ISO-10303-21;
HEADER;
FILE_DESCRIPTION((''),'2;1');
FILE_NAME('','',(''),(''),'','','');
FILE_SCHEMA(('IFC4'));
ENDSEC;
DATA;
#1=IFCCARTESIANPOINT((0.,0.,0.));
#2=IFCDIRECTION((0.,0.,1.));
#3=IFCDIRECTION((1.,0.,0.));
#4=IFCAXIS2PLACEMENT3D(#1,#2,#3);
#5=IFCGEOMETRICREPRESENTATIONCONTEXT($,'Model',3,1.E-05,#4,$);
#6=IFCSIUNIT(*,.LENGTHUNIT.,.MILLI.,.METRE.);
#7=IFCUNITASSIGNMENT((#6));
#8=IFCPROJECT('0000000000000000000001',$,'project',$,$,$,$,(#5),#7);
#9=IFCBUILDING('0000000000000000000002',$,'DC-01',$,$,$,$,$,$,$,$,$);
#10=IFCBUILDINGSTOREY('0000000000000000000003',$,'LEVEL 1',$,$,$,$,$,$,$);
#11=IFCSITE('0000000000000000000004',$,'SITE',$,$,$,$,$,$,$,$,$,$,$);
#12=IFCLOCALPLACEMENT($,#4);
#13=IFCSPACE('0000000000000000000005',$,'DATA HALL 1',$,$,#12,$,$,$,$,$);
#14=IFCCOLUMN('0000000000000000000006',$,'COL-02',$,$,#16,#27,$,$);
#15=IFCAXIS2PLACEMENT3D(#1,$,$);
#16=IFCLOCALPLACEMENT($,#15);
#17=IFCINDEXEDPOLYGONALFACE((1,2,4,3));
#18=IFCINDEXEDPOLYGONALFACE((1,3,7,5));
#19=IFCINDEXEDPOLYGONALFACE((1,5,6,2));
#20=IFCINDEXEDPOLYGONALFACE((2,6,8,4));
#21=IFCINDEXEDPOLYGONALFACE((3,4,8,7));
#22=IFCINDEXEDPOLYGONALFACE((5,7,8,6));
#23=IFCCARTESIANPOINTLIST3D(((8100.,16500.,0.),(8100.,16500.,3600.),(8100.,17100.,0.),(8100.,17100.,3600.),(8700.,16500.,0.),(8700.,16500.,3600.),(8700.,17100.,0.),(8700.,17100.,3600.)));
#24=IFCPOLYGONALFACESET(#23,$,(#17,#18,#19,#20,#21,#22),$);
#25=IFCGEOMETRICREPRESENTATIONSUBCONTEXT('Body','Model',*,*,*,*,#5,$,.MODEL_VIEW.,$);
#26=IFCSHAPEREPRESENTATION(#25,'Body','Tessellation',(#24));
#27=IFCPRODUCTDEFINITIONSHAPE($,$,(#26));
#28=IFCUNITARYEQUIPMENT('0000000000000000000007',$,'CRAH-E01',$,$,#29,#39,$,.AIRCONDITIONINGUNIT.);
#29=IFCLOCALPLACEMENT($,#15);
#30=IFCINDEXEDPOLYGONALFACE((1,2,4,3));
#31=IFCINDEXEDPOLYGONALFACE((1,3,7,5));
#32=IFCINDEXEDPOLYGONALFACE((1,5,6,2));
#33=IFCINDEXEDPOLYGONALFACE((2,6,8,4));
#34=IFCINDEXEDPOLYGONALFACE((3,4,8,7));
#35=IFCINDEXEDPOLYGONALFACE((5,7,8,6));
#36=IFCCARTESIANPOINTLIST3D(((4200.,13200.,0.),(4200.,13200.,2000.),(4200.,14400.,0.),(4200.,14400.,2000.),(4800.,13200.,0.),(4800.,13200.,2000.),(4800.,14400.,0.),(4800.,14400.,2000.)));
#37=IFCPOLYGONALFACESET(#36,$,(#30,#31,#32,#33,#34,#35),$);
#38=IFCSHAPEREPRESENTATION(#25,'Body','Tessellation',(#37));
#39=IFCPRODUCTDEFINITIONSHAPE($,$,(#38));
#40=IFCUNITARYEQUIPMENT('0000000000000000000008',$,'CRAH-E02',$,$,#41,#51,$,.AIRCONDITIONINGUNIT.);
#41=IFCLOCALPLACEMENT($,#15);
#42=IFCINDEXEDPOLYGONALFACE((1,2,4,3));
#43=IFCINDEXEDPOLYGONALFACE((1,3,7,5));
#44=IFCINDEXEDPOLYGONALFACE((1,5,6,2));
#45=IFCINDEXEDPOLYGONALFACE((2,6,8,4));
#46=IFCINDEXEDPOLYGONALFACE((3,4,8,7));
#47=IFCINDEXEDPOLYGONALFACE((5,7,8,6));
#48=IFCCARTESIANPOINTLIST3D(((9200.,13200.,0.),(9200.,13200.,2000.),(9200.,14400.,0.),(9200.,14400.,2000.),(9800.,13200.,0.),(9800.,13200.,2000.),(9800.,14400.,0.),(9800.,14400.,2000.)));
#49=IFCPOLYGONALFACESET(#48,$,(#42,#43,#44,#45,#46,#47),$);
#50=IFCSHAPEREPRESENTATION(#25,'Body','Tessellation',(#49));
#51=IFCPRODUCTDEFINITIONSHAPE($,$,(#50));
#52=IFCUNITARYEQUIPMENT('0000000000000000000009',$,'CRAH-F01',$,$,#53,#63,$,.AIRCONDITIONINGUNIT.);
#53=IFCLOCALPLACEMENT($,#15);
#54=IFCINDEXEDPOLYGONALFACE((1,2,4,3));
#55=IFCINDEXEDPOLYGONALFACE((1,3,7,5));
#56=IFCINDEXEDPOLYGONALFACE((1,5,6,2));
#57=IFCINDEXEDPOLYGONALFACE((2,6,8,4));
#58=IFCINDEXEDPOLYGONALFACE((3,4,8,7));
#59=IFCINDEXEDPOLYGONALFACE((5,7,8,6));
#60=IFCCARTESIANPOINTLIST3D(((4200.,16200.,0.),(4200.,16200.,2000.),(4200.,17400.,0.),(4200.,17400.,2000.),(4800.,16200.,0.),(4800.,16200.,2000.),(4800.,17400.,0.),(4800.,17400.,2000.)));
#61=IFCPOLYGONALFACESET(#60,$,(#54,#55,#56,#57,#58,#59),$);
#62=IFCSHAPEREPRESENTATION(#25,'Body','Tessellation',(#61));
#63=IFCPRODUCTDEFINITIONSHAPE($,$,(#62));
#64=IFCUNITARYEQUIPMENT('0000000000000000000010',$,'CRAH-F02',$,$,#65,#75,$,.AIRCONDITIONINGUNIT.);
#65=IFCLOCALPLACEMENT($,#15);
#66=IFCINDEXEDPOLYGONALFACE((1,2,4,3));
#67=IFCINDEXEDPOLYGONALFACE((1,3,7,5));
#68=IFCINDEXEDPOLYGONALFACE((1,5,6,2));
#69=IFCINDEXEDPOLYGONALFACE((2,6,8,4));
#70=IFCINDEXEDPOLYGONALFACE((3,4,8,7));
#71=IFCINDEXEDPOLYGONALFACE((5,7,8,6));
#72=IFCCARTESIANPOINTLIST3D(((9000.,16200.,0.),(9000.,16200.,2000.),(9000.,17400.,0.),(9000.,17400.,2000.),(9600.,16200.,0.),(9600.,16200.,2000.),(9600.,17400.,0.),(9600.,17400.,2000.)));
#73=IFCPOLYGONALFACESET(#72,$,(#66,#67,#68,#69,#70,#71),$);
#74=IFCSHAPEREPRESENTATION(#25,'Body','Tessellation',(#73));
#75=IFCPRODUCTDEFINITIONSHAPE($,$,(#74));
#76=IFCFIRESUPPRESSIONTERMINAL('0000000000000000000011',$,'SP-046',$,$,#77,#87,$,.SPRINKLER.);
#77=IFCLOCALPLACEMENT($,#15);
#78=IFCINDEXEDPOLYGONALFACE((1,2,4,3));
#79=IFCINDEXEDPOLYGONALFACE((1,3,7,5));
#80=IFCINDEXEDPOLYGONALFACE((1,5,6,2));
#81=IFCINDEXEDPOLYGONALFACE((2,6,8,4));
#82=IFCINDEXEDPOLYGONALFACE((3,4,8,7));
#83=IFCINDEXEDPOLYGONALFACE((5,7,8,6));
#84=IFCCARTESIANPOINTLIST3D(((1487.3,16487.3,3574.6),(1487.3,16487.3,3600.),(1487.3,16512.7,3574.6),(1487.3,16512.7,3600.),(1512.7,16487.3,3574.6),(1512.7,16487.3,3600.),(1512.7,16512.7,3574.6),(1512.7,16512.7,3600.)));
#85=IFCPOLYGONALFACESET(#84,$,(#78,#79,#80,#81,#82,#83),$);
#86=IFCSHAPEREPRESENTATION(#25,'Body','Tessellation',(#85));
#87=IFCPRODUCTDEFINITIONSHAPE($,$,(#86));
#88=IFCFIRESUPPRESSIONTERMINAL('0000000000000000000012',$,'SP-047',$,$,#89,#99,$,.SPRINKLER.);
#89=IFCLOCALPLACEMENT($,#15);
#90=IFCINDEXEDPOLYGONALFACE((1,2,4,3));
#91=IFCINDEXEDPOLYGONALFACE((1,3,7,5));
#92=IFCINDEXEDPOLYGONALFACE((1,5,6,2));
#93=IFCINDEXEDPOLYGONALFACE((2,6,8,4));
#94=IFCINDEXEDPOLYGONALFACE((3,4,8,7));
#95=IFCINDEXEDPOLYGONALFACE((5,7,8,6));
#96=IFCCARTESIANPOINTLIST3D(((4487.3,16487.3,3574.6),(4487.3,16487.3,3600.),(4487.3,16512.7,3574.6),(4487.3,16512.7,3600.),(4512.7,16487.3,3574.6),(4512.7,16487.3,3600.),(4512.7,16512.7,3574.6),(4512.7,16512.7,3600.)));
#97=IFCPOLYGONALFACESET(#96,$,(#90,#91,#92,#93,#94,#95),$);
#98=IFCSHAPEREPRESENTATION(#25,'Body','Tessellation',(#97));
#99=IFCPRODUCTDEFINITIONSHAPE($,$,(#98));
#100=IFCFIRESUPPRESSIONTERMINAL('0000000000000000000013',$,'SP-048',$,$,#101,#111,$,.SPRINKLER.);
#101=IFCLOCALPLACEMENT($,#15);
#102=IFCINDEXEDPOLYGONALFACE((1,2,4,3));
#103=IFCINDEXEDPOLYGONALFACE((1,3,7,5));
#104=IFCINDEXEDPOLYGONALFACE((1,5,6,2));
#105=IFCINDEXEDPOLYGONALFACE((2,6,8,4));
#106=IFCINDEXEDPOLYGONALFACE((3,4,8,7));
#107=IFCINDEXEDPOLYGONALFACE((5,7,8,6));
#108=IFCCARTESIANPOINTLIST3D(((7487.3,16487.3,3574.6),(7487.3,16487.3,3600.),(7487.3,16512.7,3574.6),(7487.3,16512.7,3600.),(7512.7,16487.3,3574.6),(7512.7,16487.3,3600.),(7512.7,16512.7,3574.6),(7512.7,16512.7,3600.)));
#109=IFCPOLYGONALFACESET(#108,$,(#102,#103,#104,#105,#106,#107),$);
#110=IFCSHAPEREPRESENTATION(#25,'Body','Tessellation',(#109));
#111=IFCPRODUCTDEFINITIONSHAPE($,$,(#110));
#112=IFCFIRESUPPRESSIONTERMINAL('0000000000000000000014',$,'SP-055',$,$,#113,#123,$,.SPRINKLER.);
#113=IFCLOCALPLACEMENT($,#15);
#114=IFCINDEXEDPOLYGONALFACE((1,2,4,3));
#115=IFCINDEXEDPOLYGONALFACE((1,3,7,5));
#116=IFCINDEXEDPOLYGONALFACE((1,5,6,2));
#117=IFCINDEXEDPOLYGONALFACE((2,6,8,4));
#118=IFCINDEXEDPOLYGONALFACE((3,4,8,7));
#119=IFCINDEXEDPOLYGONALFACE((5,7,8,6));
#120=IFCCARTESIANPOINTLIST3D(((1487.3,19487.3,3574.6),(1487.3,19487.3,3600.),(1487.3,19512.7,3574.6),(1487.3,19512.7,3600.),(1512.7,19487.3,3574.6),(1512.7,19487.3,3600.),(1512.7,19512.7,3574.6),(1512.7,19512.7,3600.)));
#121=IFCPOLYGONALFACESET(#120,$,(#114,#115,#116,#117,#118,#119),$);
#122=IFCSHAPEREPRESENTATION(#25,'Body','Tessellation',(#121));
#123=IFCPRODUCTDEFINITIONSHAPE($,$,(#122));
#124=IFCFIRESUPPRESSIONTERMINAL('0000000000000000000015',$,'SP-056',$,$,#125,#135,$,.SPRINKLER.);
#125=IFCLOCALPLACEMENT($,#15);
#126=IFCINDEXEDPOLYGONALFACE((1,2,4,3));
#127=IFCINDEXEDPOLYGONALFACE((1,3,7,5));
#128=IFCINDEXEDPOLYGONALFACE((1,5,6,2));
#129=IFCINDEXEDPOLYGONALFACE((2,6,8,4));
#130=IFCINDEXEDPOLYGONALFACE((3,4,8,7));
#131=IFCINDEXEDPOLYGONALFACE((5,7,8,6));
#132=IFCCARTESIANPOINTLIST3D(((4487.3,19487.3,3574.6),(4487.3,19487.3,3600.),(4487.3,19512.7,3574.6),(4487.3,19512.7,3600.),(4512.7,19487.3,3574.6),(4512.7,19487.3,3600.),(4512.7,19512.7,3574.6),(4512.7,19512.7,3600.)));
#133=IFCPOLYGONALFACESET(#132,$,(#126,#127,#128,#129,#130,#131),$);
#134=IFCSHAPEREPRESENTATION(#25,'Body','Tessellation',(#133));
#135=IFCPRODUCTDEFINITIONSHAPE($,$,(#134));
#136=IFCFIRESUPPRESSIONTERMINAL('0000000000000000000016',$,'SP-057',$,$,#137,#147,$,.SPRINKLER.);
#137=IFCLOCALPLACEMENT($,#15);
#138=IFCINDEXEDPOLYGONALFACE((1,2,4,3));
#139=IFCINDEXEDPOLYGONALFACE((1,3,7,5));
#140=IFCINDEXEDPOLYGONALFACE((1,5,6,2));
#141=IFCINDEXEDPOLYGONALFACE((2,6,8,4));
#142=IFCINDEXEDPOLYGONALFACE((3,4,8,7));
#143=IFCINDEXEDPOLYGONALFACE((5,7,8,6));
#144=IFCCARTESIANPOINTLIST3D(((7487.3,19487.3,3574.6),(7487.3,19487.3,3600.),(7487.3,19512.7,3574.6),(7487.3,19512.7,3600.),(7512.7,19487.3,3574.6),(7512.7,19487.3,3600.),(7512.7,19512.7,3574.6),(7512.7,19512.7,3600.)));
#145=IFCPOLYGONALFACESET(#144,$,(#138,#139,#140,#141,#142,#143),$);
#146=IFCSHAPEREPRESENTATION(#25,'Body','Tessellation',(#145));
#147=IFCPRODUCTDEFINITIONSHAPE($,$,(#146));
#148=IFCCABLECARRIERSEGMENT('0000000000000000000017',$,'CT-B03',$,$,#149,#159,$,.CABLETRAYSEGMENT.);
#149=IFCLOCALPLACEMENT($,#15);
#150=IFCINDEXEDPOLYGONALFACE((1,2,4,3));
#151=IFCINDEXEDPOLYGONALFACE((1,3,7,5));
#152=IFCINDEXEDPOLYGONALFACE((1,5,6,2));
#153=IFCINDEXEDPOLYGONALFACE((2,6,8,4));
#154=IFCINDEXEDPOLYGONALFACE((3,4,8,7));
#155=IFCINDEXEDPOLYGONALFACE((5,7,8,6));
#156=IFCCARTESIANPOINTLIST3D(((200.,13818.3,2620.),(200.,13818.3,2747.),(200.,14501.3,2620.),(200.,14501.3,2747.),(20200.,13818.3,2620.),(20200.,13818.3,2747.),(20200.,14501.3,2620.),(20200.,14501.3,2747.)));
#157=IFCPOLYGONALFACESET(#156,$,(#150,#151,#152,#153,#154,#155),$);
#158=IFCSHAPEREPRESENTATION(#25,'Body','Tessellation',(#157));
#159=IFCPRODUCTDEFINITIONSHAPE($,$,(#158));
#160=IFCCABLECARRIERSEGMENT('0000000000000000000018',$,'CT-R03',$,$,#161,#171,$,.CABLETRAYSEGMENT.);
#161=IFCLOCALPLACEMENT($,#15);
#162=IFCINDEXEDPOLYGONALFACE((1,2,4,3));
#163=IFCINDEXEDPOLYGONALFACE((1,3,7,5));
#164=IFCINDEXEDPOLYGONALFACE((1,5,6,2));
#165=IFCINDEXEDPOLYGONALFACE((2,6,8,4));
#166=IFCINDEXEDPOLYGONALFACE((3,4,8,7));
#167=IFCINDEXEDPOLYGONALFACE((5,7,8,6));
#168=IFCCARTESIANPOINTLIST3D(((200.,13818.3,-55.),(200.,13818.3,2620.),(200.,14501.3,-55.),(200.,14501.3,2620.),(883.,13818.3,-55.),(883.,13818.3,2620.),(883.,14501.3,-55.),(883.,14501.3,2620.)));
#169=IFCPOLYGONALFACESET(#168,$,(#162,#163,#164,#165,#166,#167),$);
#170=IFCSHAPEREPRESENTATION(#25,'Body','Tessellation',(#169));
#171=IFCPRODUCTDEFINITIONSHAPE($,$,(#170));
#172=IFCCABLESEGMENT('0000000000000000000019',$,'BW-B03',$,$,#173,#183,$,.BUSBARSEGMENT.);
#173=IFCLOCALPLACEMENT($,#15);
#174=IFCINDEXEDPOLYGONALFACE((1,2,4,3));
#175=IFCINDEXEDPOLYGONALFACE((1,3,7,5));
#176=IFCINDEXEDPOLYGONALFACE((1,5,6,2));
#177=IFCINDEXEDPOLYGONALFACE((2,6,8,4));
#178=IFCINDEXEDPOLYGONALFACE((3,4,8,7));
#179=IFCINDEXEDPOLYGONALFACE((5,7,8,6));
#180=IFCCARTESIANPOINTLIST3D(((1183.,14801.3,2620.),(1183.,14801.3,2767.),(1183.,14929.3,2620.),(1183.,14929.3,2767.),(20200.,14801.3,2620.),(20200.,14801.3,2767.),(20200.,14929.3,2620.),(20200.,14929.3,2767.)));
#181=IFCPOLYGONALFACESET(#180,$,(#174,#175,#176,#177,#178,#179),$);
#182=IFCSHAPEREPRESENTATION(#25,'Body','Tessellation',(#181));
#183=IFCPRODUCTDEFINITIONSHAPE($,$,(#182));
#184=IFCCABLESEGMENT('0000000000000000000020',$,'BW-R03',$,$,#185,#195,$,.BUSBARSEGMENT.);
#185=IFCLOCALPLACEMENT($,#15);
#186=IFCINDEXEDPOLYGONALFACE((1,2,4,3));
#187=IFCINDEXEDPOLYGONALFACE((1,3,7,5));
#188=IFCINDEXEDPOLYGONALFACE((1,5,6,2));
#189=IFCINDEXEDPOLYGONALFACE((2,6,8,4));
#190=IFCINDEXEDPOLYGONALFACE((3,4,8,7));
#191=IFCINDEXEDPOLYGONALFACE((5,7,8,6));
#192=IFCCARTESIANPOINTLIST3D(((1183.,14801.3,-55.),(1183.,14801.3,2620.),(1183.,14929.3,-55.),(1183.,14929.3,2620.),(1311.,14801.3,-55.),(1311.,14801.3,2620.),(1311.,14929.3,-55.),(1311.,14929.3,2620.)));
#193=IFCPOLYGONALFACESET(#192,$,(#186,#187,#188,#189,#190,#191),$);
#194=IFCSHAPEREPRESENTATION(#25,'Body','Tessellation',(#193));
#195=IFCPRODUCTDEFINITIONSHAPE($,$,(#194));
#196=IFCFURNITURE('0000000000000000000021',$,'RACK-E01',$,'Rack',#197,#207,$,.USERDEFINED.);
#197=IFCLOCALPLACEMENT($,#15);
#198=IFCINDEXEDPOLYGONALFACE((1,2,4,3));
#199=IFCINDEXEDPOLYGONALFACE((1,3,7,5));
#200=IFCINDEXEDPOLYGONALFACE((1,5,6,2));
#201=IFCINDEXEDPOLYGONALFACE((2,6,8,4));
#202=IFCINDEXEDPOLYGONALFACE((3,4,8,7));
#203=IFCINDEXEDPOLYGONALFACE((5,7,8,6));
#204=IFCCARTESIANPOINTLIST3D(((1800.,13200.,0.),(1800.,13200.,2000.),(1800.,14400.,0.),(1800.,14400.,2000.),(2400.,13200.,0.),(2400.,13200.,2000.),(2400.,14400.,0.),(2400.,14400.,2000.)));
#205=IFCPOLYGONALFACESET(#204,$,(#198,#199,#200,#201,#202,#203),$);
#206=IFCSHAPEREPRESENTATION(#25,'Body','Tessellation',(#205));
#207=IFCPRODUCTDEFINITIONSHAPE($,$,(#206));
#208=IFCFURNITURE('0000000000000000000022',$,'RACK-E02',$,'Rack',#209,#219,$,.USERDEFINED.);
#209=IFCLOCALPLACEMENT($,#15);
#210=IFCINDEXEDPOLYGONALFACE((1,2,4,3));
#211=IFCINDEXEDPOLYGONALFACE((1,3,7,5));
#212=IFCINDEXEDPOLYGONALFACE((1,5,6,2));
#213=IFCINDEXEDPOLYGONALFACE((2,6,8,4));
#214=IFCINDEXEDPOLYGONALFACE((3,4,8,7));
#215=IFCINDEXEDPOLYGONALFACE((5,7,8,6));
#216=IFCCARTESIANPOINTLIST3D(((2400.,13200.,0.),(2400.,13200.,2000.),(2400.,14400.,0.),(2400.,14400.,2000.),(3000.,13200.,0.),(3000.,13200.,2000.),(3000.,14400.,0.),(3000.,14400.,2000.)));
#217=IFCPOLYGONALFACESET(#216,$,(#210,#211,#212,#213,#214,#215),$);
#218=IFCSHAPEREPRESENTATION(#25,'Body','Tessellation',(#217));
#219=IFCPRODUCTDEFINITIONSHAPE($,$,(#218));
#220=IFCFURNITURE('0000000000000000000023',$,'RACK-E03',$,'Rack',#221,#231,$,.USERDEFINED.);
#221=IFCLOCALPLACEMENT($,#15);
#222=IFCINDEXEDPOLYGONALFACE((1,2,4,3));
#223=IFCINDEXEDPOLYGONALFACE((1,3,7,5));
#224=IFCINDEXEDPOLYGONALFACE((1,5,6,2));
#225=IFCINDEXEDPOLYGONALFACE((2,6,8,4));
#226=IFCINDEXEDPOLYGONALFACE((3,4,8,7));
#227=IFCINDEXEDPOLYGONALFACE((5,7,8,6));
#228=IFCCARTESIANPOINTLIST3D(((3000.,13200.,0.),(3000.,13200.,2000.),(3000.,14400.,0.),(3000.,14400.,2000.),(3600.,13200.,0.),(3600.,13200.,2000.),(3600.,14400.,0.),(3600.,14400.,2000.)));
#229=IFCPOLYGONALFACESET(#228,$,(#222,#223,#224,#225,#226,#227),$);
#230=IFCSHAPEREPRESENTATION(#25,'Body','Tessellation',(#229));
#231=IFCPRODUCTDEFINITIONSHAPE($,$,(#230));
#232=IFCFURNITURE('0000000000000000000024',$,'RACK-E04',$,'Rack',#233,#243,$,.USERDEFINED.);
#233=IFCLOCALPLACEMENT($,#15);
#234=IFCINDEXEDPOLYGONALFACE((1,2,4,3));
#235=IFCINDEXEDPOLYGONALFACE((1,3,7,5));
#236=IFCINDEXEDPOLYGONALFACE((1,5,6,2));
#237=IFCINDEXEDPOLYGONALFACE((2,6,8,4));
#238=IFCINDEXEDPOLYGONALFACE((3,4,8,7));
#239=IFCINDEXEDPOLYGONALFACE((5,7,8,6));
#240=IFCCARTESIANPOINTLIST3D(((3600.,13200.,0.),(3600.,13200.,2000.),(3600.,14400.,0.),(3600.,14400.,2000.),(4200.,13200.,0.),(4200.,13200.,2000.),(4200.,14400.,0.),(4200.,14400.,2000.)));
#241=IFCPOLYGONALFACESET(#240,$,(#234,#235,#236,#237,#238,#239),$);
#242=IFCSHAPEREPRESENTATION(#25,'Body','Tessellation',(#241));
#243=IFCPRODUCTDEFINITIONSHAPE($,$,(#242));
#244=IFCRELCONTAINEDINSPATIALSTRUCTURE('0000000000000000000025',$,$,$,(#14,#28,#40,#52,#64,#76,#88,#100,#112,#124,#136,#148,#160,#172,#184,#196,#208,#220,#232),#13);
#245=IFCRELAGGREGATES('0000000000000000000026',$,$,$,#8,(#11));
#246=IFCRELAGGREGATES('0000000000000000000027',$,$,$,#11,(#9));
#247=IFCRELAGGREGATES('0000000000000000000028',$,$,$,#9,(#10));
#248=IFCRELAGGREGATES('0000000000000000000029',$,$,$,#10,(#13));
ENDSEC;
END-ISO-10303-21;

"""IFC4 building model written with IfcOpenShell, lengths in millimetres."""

from ifc_helpers import new_model, si_unit, frame, origin, origin_with_axes, place, context, subcontext, project, spatial, polyline, outline, extrude, element, save


model = new_model("IFC4")

# Units and contexts
model_context = context("Model", 3, precision=1e-05, world=origin_with_axes())
body_context = subcontext(model_context, "Body", "Model", "MODEL_VIEW")
ifc_project = project(units=[si_unit("LENGTHUNIT", "METRE", prefix="MILLI")], contexts=[model_context])

# Site, building, storey, space
site = spatial("IfcSite", under=ifc_project, Name="SITE")
building = spatial("IfcBuilding", under=site, Name="DC-01")
storey = spatial("IfcBuildingStorey", under=building, Name="LEVEL 1")
space_placement = place(None, origin_with_axes())
space = spatial("IfcSpace", under=storey, at=space_placement, Name="DATA HALL 1")

# Column
column_placement = place(space_placement, frame((8100.0, 16500.0, 0.0), z_axis=(0.0, 0.0, 1.0), x_axis=(1.0, 0.0, 0.0)))
element("IfcColumn", 1, at=column_placement, inside=space, Name="COL-02", context=body_context, shape_type="SweptSolid", body=[
    extrude(outline(polyline([(0.0, 0.0), (600.0, 0.0), (600.0, 600.0), (0.0, 600.0), (0.0, 0.0)])), origin(), (0.0, 0.0, 1.0), 3600.0),
])

# Unitary equipment
for number, where, z_axis, x_axis, name in (
    (2, (4800.0, 14400.0, 0.0), (0.0, 0.0, 1.0), (-1.0, 0.0, 0.0), "CRAH-E01"),
    (3, (9800.0, 14400.0, 0.0), (0.0, 0.0, 1.0), (-1.0, 0.0, 0.0), "CRAH-E02"),
    (4, (4200.0, 16200.0, 0.0), (0.0, 0.0, 1.0), (1.0, 0.0, 0.0), "CRAH-F01"),
    (5, (9000.0, 16200.0, 0.0), (0.0, 0.0, 1.0), (1.0, 0.0, 0.0), "CRAH-F02"),
):
    element("IfcUnitaryEquipment", number, at=place(space_placement, frame(where, z_axis=z_axis, x_axis=x_axis)), inside=space, Name=name, PredefinedType="AIRCONDITIONINGUNIT", context=body_context, shape_type="SweptSolid", body=[
        extrude(outline(polyline([(0.0, 0.0), (600.0, 0.0), (600.0, 1200.0), (0.0, 1200.0), (0.0, 0.0)])), origin(), (0.0, 0.0, 1.0), 2000.0),
    ])

# Fire suppression terminals
for number, where, z_axis, x_axis, name in (
    (6, (1487.3, 16487.3, 3574.6), (0.0, 0.0, 1.0), (1.0, 0.0, 0.0), "SP-046"),
    (7, (4487.3, 16487.3, 3574.6), (0.0, 0.0, 1.0), (1.0, 0.0, 0.0), "SP-047"),
    (8, (7487.3, 16487.3, 3574.6), (0.0, 0.0, 1.0), (1.0, 0.0, 0.0), "SP-048"),
    (9, (1487.3, 19487.3, 3574.6), (0.0, 0.0, 1.0), (1.0, 0.0, 0.0), "SP-055"),
    (10, (4487.3, 19487.3, 3574.6), (0.0, 0.0, 1.0), (1.0, 0.0, 0.0), "SP-056"),
    (11, (7487.3, 19487.3, 3574.6), (0.0, 0.0, 1.0), (1.0, 0.0, 0.0), "SP-057"),
):
    element("IfcFireSuppressionTerminal", number, at=place(space_placement, frame(where, z_axis=z_axis, x_axis=x_axis)), inside=space, Name=name, PredefinedType="SPRINKLER", context=body_context, shape_type="SweptSolid", body=[
        extrude(outline(polyline([(0.0, 0.0), (25.4, 0.0), (25.4, 25.4), (0.0, 25.4), (0.0, 0.0)])), origin(), (0.0, 0.0, 1.0), 25.4),
    ])

# Cable carrier segments
cable_carrier_segment_1_placement = place(space_placement, frame((200.0, 13818.3, 2620.0), z_axis=(0.0, 0.0, 1.0), x_axis=(1.0, 0.0, 0.0)))
element("IfcCableCarrierSegment", 12, at=cable_carrier_segment_1_placement, inside=space, Name="CT-B03", PredefinedType="CABLETRAYSEGMENT", context=body_context, shape_type="SweptSolid", body=[
    extrude(outline(polyline([(0.0, 0.0), (20000.0, 0.0), (20000.0, 683.0), (0.0, 683.0), (0.0, 0.0)])), origin(), (0.0, 0.0, 1.0), 127.0),
])
cable_carrier_segment_2_placement = place(space_placement, frame((200.0, 13818.3, -55.0), z_axis=(0.0, 0.0, 1.0), x_axis=(1.0, 0.0, 0.0)))
element("IfcCableCarrierSegment", 13, at=cable_carrier_segment_2_placement, inside=space, Name="CT-R03", PredefinedType="CABLETRAYSEGMENT", context=body_context, shape_type="SweptSolid", body=[
    extrude(outline(polyline([(0.0, 0.0), (683.0, 0.0), (683.0, 683.0), (0.0, 683.0), (0.0, 0.0)])), origin(), (0.0, 0.0, 1.0), 2675.0),
])

# Cable segments
cable_segment_1_placement = place(space_placement, frame((1183.0, 14801.3, 2620.0), z_axis=(0.0, 0.0, 1.0), x_axis=(1.0, 0.0, 0.0)))
element("IfcCableSegment", 14, at=cable_segment_1_placement, inside=space, Name="BW-B03", PredefinedType="BUSBARSEGMENT", context=body_context, shape_type="SweptSolid", body=[
    extrude(outline(polyline([(0.0, 0.0), (19017.0, 0.0), (19017.0, 128.0), (0.0, 128.0), (0.0, 0.0)])), origin(), (0.0, 0.0, 1.0), 147.0),
])
cable_segment_2_placement = place(space_placement, frame((1183.0, 14801.3, -55.0), z_axis=(0.0, 0.0, 1.0), x_axis=(1.0, 0.0, 0.0)))
element("IfcCableSegment", 15, at=cable_segment_2_placement, inside=space, Name="BW-R03", PredefinedType="BUSBARSEGMENT", context=body_context, shape_type="SweptSolid", body=[
    extrude(outline(polyline([(0.0, 0.0), (128.0, 0.0), (128.0, 128.0), (0.0, 128.0), (0.0, 0.0)])), origin(), (0.0, 0.0, 1.0), 2675.0),
])

# Furniture
for number, where, z_axis, x_axis, name in (
    (16, (2400.0, 14400.0, 0.0), (0.0, 0.0, 1.0), (-1.0, 0.0, 0.0), "RACK-E01"),
    (17, (3000.0, 14400.0, 0.0), (0.0, 0.0, 1.0), (-1.0, 0.0, 0.0), "RACK-E02"),
    (18, (3600.0, 14400.0, 0.0), (0.0, 0.0, 1.0), (-1.0, 0.0, 0.0), "RACK-E03"),
    (19, (4200.0, 14400.0, 0.0), (0.0, 0.0, 1.0), (-1.0, 0.0, 0.0), "RACK-E04"),
):
    element("IfcFurniture", number, at=place(space_placement, frame(where, z_axis=z_axis, x_axis=x_axis)), inside=space, Name=name, ObjectType="Rack", PredefinedType="USERDEFINED", context=body_context, shape_type="SweptSolid", body=[
        extrude(outline(polyline([(0.0, 0.0), (600.0, 0.0), (600.0, 1200.0), (0.0, 1200.0), (0.0, 0.0)])), origin(), (0.0, 0.0, 1.0), 2000.0),
    ])

save(model, "model.ifc")
